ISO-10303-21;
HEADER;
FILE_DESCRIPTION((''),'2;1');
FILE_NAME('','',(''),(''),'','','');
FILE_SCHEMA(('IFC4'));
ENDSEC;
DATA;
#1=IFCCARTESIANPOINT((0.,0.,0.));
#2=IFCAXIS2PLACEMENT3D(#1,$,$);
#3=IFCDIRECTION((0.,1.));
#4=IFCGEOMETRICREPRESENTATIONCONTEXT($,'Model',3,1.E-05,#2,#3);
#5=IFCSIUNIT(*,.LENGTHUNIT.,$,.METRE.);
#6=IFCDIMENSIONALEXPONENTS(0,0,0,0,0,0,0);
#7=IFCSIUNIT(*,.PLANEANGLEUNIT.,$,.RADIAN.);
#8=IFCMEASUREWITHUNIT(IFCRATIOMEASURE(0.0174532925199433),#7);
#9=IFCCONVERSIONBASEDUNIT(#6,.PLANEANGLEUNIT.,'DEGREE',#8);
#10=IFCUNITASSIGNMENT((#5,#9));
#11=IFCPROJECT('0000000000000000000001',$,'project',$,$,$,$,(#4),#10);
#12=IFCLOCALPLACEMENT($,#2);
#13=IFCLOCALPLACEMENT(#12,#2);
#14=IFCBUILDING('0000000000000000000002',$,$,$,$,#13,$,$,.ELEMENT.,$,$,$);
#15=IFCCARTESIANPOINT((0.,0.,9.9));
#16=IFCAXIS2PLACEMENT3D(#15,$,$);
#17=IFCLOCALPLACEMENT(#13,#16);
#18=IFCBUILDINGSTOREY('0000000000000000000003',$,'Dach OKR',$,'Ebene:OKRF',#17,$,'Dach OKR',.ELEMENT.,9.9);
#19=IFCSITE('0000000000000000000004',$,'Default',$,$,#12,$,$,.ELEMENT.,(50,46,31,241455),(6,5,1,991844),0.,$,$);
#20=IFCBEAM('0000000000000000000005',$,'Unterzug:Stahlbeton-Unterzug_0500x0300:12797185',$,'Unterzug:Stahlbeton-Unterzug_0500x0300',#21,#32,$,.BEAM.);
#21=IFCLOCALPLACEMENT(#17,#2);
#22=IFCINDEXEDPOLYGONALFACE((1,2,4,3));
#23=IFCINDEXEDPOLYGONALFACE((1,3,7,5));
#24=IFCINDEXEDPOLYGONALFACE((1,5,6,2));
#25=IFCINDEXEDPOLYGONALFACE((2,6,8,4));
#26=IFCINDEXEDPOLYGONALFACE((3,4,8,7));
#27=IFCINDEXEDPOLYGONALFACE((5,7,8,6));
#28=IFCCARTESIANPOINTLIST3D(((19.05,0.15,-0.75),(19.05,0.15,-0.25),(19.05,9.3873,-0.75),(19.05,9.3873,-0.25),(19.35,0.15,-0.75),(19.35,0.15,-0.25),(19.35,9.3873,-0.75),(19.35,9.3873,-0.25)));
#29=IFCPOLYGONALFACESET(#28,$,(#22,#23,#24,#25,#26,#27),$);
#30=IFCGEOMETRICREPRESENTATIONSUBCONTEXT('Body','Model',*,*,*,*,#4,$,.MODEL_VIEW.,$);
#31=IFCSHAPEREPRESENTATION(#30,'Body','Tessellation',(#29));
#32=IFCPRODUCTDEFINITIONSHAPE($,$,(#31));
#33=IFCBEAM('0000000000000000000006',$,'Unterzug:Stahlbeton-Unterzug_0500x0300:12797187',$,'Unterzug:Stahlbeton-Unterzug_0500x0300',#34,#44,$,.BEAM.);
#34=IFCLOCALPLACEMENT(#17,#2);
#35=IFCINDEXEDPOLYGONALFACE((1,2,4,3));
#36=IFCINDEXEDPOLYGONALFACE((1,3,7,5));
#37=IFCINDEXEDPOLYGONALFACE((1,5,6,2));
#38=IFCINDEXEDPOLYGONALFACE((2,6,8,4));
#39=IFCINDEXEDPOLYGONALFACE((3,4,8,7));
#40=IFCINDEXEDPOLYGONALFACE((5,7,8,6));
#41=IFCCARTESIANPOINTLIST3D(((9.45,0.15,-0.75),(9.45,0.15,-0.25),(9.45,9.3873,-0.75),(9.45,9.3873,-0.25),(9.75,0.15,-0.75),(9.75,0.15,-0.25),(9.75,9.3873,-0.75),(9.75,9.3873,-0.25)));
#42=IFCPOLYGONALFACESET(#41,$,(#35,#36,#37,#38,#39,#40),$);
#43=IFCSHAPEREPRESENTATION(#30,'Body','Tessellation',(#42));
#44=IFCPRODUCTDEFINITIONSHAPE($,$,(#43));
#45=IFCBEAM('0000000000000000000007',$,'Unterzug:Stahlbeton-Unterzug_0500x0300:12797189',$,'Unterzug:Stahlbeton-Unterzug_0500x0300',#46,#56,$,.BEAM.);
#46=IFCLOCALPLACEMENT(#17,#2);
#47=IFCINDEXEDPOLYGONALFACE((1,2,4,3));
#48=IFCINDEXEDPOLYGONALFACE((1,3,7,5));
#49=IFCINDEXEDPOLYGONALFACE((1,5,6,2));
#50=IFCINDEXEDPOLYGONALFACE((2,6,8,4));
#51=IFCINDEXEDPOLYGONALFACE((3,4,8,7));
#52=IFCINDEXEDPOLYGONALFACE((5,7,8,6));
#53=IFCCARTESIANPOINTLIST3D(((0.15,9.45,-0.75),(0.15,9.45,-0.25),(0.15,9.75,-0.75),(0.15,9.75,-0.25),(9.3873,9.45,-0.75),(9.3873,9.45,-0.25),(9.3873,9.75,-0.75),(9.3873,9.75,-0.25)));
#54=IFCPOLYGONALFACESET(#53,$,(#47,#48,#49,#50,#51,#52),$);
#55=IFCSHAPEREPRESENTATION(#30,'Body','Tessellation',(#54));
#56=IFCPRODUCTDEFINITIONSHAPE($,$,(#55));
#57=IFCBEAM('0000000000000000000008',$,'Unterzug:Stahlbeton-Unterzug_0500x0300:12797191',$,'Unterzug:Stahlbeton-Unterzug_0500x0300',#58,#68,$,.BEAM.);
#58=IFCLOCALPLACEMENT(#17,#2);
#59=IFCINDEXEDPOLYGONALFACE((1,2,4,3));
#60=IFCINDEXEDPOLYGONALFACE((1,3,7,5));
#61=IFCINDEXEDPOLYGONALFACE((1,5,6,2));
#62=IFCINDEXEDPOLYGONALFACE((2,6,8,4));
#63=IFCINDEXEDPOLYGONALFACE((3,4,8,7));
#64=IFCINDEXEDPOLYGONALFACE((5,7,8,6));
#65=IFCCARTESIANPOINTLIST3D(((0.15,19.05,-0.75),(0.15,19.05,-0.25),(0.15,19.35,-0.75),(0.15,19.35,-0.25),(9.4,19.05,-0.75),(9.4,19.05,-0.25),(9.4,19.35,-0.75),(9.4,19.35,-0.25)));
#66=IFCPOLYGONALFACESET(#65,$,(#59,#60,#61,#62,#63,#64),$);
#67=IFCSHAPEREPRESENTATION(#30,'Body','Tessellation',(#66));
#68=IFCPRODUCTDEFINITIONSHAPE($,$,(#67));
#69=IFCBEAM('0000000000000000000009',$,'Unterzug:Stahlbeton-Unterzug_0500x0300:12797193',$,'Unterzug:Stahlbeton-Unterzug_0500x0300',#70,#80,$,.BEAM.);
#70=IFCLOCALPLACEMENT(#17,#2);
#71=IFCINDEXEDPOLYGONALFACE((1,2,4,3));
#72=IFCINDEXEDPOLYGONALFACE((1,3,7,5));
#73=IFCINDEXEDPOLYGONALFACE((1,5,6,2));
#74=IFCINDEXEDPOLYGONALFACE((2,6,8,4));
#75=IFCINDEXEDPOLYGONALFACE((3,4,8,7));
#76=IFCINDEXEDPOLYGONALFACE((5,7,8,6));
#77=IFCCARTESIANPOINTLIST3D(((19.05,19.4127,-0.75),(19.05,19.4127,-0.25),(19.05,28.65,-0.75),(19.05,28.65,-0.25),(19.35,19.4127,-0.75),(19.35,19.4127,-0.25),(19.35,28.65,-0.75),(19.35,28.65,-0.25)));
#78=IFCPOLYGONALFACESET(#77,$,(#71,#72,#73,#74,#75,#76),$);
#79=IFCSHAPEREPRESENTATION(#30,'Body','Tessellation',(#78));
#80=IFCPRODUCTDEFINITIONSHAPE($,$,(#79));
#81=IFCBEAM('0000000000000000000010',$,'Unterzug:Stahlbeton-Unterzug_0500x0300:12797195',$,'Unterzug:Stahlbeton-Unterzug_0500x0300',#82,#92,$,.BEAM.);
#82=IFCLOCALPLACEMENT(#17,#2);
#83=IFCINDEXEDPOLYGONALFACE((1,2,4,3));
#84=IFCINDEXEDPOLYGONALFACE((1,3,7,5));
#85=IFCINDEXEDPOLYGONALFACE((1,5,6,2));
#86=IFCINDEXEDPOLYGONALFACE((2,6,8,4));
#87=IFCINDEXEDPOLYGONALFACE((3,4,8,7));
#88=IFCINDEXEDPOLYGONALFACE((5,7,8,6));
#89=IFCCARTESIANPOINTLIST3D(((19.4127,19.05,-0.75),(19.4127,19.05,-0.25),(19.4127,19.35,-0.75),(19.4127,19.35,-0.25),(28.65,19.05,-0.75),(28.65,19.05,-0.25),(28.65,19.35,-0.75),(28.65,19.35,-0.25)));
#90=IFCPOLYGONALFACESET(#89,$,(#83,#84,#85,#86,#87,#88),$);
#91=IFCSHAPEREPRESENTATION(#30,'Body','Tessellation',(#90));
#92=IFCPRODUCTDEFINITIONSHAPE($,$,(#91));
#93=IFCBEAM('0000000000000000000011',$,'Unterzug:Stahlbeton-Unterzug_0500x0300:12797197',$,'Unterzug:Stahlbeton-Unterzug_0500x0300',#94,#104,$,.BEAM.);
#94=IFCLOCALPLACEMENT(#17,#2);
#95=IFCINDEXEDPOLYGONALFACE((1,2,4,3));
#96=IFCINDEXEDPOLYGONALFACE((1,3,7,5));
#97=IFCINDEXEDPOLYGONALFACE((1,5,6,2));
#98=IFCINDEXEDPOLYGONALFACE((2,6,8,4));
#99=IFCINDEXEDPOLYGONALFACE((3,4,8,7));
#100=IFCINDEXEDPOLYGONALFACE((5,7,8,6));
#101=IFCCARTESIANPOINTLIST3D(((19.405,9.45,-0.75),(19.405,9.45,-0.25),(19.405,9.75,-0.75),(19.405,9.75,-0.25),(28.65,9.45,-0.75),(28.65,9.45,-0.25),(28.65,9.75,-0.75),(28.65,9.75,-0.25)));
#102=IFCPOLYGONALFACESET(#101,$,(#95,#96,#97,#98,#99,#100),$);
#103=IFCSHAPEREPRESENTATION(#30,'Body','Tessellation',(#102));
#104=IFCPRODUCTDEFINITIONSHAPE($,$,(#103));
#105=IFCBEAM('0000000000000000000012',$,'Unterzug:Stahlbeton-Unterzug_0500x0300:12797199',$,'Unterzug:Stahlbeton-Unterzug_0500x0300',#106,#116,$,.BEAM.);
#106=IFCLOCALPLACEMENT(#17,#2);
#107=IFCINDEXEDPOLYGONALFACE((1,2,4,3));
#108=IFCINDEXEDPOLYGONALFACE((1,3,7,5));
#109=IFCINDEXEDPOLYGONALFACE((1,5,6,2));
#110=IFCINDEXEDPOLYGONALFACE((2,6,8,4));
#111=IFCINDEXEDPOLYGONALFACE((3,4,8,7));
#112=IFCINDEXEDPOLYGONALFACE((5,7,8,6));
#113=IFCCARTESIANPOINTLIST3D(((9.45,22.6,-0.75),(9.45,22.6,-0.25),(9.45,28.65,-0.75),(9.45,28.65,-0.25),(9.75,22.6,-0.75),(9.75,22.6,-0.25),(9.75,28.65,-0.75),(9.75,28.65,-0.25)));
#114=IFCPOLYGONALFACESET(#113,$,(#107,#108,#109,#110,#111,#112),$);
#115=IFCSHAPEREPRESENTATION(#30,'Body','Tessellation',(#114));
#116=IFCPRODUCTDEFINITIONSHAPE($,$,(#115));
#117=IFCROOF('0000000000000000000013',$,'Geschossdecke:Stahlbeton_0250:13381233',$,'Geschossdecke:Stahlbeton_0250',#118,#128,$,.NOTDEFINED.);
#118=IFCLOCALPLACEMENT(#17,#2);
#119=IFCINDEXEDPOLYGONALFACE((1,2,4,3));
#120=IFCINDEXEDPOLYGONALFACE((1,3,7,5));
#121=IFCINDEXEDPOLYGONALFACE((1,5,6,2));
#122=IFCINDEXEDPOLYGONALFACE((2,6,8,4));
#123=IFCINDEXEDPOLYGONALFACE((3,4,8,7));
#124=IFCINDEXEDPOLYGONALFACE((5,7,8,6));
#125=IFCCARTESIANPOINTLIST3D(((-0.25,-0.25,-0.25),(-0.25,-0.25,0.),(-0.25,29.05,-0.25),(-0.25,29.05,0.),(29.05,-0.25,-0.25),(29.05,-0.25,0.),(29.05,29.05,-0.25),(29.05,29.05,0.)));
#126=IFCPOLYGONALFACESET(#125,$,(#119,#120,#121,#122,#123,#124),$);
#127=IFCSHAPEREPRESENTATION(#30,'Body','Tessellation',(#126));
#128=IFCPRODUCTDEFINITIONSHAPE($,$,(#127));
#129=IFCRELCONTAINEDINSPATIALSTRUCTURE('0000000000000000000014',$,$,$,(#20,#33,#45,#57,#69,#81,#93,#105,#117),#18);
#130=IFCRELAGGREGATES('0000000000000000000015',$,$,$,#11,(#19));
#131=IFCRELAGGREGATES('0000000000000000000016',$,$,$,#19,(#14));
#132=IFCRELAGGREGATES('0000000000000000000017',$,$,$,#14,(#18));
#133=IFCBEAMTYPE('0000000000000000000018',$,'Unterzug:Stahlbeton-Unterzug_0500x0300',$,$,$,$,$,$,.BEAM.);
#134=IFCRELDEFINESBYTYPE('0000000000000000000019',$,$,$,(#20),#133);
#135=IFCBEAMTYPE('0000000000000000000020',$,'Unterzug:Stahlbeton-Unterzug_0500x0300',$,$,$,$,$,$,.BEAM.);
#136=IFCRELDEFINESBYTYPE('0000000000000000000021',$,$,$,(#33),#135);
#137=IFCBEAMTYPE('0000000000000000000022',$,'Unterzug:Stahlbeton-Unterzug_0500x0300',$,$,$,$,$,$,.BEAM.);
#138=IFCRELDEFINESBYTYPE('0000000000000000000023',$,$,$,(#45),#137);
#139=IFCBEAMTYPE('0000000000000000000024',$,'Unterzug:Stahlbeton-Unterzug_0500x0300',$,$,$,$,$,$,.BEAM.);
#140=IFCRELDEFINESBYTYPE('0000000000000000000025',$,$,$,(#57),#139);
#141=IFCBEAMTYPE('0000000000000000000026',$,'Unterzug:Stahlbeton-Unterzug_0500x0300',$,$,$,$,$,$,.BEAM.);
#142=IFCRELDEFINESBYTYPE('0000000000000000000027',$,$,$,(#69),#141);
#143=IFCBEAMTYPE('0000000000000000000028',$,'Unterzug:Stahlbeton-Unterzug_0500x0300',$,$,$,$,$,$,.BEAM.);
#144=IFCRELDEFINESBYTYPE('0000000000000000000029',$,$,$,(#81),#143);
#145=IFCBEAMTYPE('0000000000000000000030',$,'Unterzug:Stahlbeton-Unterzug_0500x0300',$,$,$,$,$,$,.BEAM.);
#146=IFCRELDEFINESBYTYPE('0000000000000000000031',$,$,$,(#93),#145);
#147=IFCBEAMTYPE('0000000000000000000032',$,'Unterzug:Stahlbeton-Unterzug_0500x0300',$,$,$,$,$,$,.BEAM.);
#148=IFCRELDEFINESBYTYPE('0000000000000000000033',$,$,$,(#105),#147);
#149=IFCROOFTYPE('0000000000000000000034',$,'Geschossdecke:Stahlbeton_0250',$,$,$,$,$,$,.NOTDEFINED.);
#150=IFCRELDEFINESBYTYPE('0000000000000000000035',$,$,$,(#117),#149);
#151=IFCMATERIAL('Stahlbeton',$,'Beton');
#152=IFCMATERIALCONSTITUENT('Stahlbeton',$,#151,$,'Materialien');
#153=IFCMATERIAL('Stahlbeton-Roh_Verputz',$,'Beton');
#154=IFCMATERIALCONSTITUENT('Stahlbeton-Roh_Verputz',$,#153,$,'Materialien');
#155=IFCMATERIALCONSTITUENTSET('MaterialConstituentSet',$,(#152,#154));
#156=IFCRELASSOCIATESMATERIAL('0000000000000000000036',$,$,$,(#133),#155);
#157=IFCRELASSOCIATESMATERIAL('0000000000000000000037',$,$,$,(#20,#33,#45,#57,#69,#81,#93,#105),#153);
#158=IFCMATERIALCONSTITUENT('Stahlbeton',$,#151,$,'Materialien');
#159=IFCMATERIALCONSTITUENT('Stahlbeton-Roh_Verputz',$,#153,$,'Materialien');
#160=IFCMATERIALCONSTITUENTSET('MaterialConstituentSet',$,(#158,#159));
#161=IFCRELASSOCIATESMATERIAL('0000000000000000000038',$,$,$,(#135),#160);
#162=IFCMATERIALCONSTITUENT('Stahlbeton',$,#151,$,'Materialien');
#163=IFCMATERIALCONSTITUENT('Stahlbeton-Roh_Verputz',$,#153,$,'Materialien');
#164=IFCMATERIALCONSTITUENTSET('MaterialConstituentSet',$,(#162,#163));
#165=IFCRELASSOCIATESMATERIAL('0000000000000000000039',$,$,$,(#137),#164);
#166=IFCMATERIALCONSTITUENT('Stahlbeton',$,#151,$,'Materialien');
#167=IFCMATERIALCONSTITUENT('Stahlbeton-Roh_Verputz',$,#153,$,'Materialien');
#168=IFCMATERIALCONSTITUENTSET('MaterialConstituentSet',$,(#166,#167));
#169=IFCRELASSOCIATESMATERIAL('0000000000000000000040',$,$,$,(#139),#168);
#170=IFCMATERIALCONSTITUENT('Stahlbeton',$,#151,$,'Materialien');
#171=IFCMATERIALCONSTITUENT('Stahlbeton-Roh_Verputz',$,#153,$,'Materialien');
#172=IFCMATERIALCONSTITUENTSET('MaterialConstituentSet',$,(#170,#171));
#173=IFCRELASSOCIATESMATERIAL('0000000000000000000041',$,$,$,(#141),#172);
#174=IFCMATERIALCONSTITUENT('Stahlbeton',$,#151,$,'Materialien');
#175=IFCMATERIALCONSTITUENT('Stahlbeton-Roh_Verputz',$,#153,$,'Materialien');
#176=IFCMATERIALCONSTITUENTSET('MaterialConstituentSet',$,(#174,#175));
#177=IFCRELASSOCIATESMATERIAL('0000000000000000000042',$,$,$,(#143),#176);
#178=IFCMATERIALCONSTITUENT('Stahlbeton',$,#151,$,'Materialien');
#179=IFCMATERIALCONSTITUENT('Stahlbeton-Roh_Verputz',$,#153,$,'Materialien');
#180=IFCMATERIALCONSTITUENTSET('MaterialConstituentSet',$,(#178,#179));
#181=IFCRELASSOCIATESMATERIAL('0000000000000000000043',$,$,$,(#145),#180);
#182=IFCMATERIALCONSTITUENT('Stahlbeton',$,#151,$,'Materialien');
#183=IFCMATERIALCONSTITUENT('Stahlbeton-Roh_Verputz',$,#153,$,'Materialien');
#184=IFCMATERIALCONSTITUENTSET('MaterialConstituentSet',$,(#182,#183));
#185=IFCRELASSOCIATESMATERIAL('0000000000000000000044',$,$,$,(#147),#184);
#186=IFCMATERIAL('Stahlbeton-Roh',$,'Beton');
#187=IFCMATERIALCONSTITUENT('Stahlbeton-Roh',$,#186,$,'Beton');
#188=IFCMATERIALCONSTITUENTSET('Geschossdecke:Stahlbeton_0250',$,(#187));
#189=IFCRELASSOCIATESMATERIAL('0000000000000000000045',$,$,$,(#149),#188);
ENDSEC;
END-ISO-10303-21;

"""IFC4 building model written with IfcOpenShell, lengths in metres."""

from ifc_helpers import new_model, entity, si_unit, converted_unit, direction, frame, origin, place, context, subcontext, project, spatial, polyline, indexed_curve, outline, extrude, source, transform, mapped, material, constituent, constituent_set, type_object, type_shapes, element, save


model = new_model("IFC4")

# Units and contexts
model_context = context("Model", 3, precision=1e-05, world=origin(), true_north=direction((0.0, 1.0)))
body_context = subcontext(model_context, "Body", "Model", "MODEL_VIEW")
ifc_project = project(units=[si_unit("LENGTHUNIT", "METRE"), converted_unit("PLANEANGLEUNIT", "DEGREE", entity("IfcRatioMeasure", 0.0174532925199433), si_unit("PLANEANGLEUNIT", "RADIAN"), dimensions=[0, 0, 0, 0, 0, 0, 0])], contexts=[model_context])

# Site, building, storey
site_placement = place(None, origin())
site = spatial("IfcSite", under=ifc_project, at=site_placement, Name="Default", CompositionType="ELEMENT", RefLatitude=(50, 46, 31, 241455), RefLongitude=(6, 5, 1, 991844), RefElevation=0.0)
building_placement = place(site_placement, origin())
building = spatial("IfcBuilding", under=site, at=building_placement, CompositionType="ELEMENT")
storey_placement = place(building_placement, frame((0.0, 0.0, 9.9)))
storey = spatial("IfcBuildingStorey", under=building, at=storey_placement, Name="Dach OKR", ObjectType="Ebene:OKRF", LongName="Dach OKR", CompositionType="ELEMENT", Elevation=9.9)

# Beams
ifc_material_1 = material(Name="Stahlbeton-Roh_Verputz", Category="Beton")
ifc_material_2 = material(Name="Stahlbeton", Category="Beton")
ifc_constituent_1 = constituent(ifc_material_2, Name="Stahlbeton", Category="Materialien")
ifc_constituent_2 = constituent(ifc_material_1, Name="Stahlbeton-Roh_Verputz", Category="Materialien")
ifc_constituent_set_1 = constituent_set(constituents=[ifc_constituent_1, ifc_constituent_2], Name="MaterialConstituentSet")
beam_type_1 = type_object("IfcBeamType", Name="Unterzug:Stahlbeton-Unterzug_0500x0300", PredefinedType="BEAM", material=ifc_constituent_set_1)
shared_shape_1 = source(origin(), body_context, "Body", "SweptSolid", [
    extrude(outline(indexed_curve([(-0.15, -0.25), (0.15, -0.25), (0.15, 0.25), (-0.15, 0.25), (-0.15, -0.25)], self_intersect=False)), frame((19.2, 9.3873, 9.4), z_axis=(0.0, -1.0, 0.0), x_axis=(-1.0, 0.0, 0.0)), (0.0, 0.0, 1.0), 9.2373),
])
type_shapes(beam_type_1, [shared_shape_1])
beam_1_placement = place(storey_placement, frame((0.0, 0.0, -9.9)))
element("IfcBeam", 1, at=beam_1_placement, inside=storey, type_object=beam_type_1, material=ifc_material_1, Name="Unterzug:Stahlbeton-Unterzug_0500x0300:12797185", ObjectType="Unterzug:Stahlbeton-Unterzug_0500x0300", PredefinedType="BEAM", context=body_context, shape_type="MappedRepresentation", body=[
    mapped(shared_shape_1, transform((0.0, 0.0, 0.0), scale=1.0)),
])
ifc_constituent_3 = constituent(ifc_material_2, Name="Stahlbeton", Category="Materialien")
ifc_constituent_4 = constituent(ifc_material_1, Name="Stahlbeton-Roh_Verputz", Category="Materialien")
ifc_constituent_set_2 = constituent_set(constituents=[ifc_constituent_3, ifc_constituent_4], Name="MaterialConstituentSet")
beam_type_2 = type_object("IfcBeamType", Name="Unterzug:Stahlbeton-Unterzug_0500x0300", PredefinedType="BEAM", material=ifc_constituent_set_2)
shared_shape_2 = source(origin(), body_context, "Body", "SweptSolid", [
    extrude(outline(indexed_curve([(-0.15, -0.25), (0.15, -0.25), (0.15, 0.25), (-0.15, 0.25), (-0.15, -0.25)], self_intersect=False)), frame((9.6, 9.3873, 9.4), z_axis=(0.0, -1.0, 0.0), x_axis=(-1.0, 0.0, 0.0)), (0.0, 0.0, 1.0), 9.2373),
])
type_shapes(beam_type_2, [shared_shape_2])
beam_2_placement = place(storey_placement, frame((0.0, 0.0, -9.9)))
element("IfcBeam", 2, at=beam_2_placement, inside=storey, type_object=beam_type_2, material=ifc_material_1, Name="Unterzug:Stahlbeton-Unterzug_0500x0300:12797187", ObjectType="Unterzug:Stahlbeton-Unterzug_0500x0300", PredefinedType="BEAM", context=body_context, shape_type="MappedRepresentation", body=[
    mapped(shared_shape_2, transform((0.0, 0.0, 0.0), scale=1.0)),
])
ifc_constituent_5 = constituent(ifc_material_2, Name="Stahlbeton", Category="Materialien")
ifc_constituent_6 = constituent(ifc_material_1, Name="Stahlbeton-Roh_Verputz", Category="Materialien")
ifc_constituent_set_3 = constituent_set(constituents=[ifc_constituent_5, ifc_constituent_6], Name="MaterialConstituentSet")
beam_type_3 = type_object("IfcBeamType", Name="Unterzug:Stahlbeton-Unterzug_0500x0300", PredefinedType="BEAM", material=ifc_constituent_set_3)
shared_shape_3 = source(origin(), body_context, "Body", "SweptSolid", [
    extrude(outline(indexed_curve([(-0.25, -0.15), (0.25, -0.15), (0.25, 0.15), (-0.25, 0.15), (-0.25, -0.15)], self_intersect=False)), frame((9.3873, 9.6, 9.4), z_axis=(-1.0, 0.0, 0.0), x_axis=(0.0, 0.0, -1.0)), (0.0, 0.0, 1.0), 9.2373),
])
type_shapes(beam_type_3, [shared_shape_3])
beam_3_placement = place(storey_placement, frame((0.0, 0.0, -9.9)))
element("IfcBeam", 3, at=beam_3_placement, inside=storey, type_object=beam_type_3, material=ifc_material_1, Name="Unterzug:Stahlbeton-Unterzug_0500x0300:12797189", ObjectType="Unterzug:Stahlbeton-Unterzug_0500x0300", PredefinedType="BEAM", context=body_context, shape_type="MappedRepresentation", body=[
    mapped(shared_shape_3, transform((0.0, 0.0, 0.0), scale=1.0)),
])
ifc_constituent_7 = constituent(ifc_material_2, Name="Stahlbeton", Category="Materialien")
ifc_constituent_8 = constituent(ifc_material_1, Name="Stahlbeton-Roh_Verputz", Category="Materialien")
ifc_constituent_set_4 = constituent_set(constituents=[ifc_constituent_7, ifc_constituent_8], Name="MaterialConstituentSet")
beam_type_4 = type_object("IfcBeamType", Name="Unterzug:Stahlbeton-Unterzug_0500x0300", PredefinedType="BEAM", material=ifc_constituent_set_4)
shared_shape_4 = source(origin(), body_context, "Body", "SweptSolid", [
    extrude(outline(indexed_curve([(-0.25, -0.15), (0.25, -0.15), (0.25, 0.15), (-0.25, 0.15), (-0.25, -0.15)], self_intersect=False)), frame((9.4, 19.2, 9.4), z_axis=(-1.0, 0.0, 0.0), x_axis=(0.0, 0.0, -1.0)), (0.0, 0.0, 1.0), 9.25),
])
type_shapes(beam_type_4, [shared_shape_4])
beam_4_placement = place(storey_placement, frame((0.0, 0.0, -9.9)))
element("IfcBeam", 4, at=beam_4_placement, inside=storey, type_object=beam_type_4, material=ifc_material_1, Name="Unterzug:Stahlbeton-Unterzug_0500x0300:12797191", ObjectType="Unterzug:Stahlbeton-Unterzug_0500x0300", PredefinedType="BEAM", context=body_context, shape_type="MappedRepresentation", body=[
    mapped(shared_shape_4, transform((0.0, 0.0, 0.0), scale=1.0)),
])
ifc_constituent_9 = constituent(ifc_material_2, Name="Stahlbeton", Category="Materialien")
ifc_constituent_10 = constituent(ifc_material_1, Name="Stahlbeton-Roh_Verputz", Category="Materialien")
ifc_constituent_set_5 = constituent_set(constituents=[ifc_constituent_9, ifc_constituent_10], Name="MaterialConstituentSet")
beam_type_5 = type_object("IfcBeamType", Name="Unterzug:Stahlbeton-Unterzug_0500x0300", PredefinedType="BEAM", material=ifc_constituent_set_5)
shared_shape_5 = source(origin(), body_context, "Body", "SweptSolid", [
    extrude(outline(indexed_curve([(-0.15, -0.25), (0.15, -0.25), (0.15, 0.25), (-0.15, 0.25), (-0.15, -0.25)], self_intersect=False)), frame((19.2, 19.4127, 9.4), z_axis=(0.0, 1.0, 0.0), x_axis=(-1.0, 0.0, 0.0)), (0.0, 0.0, 1.0), 9.2373),
])
type_shapes(beam_type_5, [shared_shape_5])
beam_5_placement = place(storey_placement, frame((0.0, 0.0, -9.9)))
element("IfcBeam", 5, at=beam_5_placement, inside=storey, type_object=beam_type_5, material=ifc_material_1, Name="Unterzug:Stahlbeton-Unterzug_0500x0300:12797193", ObjectType="Unterzug:Stahlbeton-Unterzug_0500x0300", PredefinedType="BEAM", context=body_context, shape_type="MappedRepresentation", body=[
    mapped(shared_shape_5, transform((0.0, 0.0, 0.0), scale=1.0)),
])
ifc_constituent_11 = constituent(ifc_material_2, Name="Stahlbeton", Category="Materialien")
ifc_constituent_12 = constituent(ifc_material_1, Name="Stahlbeton-Roh_Verputz", Category="Materialien")
ifc_constituent_set_6 = constituent_set(constituents=[ifc_constituent_11, ifc_constituent_12], Name="MaterialConstituentSet")
beam_type_6 = type_object("IfcBeamType", Name="Unterzug:Stahlbeton-Unterzug_0500x0300", PredefinedType="BEAM", material=ifc_constituent_set_6)
shared_shape_6 = source(origin(), body_context, "Body", "SweptSolid", [
    extrude(outline(indexed_curve([(-0.25, -0.15), (0.25, -0.15), (0.25, 0.15), (-0.25, 0.15), (-0.25, -0.15)], self_intersect=False)), frame((19.4127, 19.2, 9.4), z_axis=(1.0, 0.0, 0.0), x_axis=(0.0, 0.0, -1.0)), (0.0, 0.0, 1.0), 9.2373),
])
type_shapes(beam_type_6, [shared_shape_6])
beam_6_placement = place(storey_placement, frame((0.0, 0.0, -9.9)))
element("IfcBeam", 6, at=beam_6_placement, inside=storey, type_object=beam_type_6, material=ifc_material_1, Name="Unterzug:Stahlbeton-Unterzug_0500x0300:12797195", ObjectType="Unterzug:Stahlbeton-Unterzug_0500x0300", PredefinedType="BEAM", context=body_context, shape_type="MappedRepresentation", body=[
    mapped(shared_shape_6, transform((0.0, 0.0, 0.0), scale=1.0)),
])
ifc_constituent_13 = constituent(ifc_material_2, Name="Stahlbeton", Category="Materialien")
ifc_constituent_14 = constituent(ifc_material_1, Name="Stahlbeton-Roh_Verputz", Category="Materialien")
ifc_constituent_set_7 = constituent_set(constituents=[ifc_constituent_13, ifc_constituent_14], Name="MaterialConstituentSet")
beam_type_7 = type_object("IfcBeamType", Name="Unterzug:Stahlbeton-Unterzug_0500x0300", PredefinedType="BEAM", material=ifc_constituent_set_7)
shared_shape_7 = source(origin(), body_context, "Body", "SweptSolid", [
    extrude(outline(indexed_curve([(-0.25, -0.15), (0.25, -0.15), (0.25, 0.15), (-0.25, 0.15), (-0.25, -0.15)], self_intersect=False)), frame((19.405, 9.6, 9.4), z_axis=(1.0, 0.0, 0.0), x_axis=(0.0, 0.0, -1.0)), (0.0, 0.0, 1.0), 9.245),
])
type_shapes(beam_type_7, [shared_shape_7])
beam_7_placement = place(storey_placement, frame((0.0, 0.0, -9.9)))
element("IfcBeam", 7, at=beam_7_placement, inside=storey, type_object=beam_type_7, material=ifc_material_1, Name="Unterzug:Stahlbeton-Unterzug_0500x0300:12797197", ObjectType="Unterzug:Stahlbeton-Unterzug_0500x0300", PredefinedType="BEAM", context=body_context, shape_type="MappedRepresentation", body=[
    mapped(shared_shape_7, transform((0.0, 0.0, 0.0), scale=1.0)),
])
ifc_constituent_15 = constituent(ifc_material_2, Name="Stahlbeton", Category="Materialien")
ifc_constituent_16 = constituent(ifc_material_1, Name="Stahlbeton-Roh_Verputz", Category="Materialien")
ifc_constituent_set_8 = constituent_set(constituents=[ifc_constituent_15, ifc_constituent_16], Name="MaterialConstituentSet")
beam_type_8 = type_object("IfcBeamType", Name="Unterzug:Stahlbeton-Unterzug_0500x0300", PredefinedType="BEAM", material=ifc_constituent_set_8)
shared_shape_8 = source(origin(), body_context, "Body", "SweptSolid", [
    extrude(outline(indexed_curve([(-0.15, -0.25), (0.15, -0.25), (0.15, 0.25), (-0.15, 0.25), (-0.15, -0.25)], self_intersect=False)), frame((9.6, 22.6, 9.4), z_axis=(0.0, 1.0, 0.0), x_axis=(-1.0, 0.0, 0.0)), (0.0, 0.0, 1.0), 6.05),
])
type_shapes(beam_type_8, [shared_shape_8])
beam_8_placement = place(storey_placement, frame((0.0, 0.0, -9.9)))
element("IfcBeam", 8, at=beam_8_placement, inside=storey, type_object=beam_type_8, material=ifc_material_1, Name="Unterzug:Stahlbeton-Unterzug_0500x0300:12797199", ObjectType="Unterzug:Stahlbeton-Unterzug_0500x0300", PredefinedType="BEAM", context=body_context, shape_type="MappedRepresentation", body=[
    mapped(shared_shape_8, transform((0.0, 0.0, 0.0), scale=1.0)),
])

# Roof
ifc_material_3 = material(Name="Stahlbeton-Roh", Category="Beton")
ifc_constituent_17 = constituent(ifc_material_3, Name="Stahlbeton-Roh", Category="Beton")
ifc_constituent_set_9 = constituent_set(constituents=[ifc_constituent_17], Name="Geschossdecke:Stahlbeton_0250")
roof_type = type_object("IfcRoofType", Name="Geschossdecke:Stahlbeton_0250", PredefinedType="NOTDEFINED", material=ifc_constituent_set_9)
roof_1_placement = place(storey_placement, origin())
element("IfcRoof", 9, at=roof_1_placement, inside=storey, type_object=roof_type, Name="Geschossdecke:Stahlbeton_0250:13381233", ObjectType="Geschossdecke:Stahlbeton_0250", PredefinedType="NOTDEFINED", context=body_context, shape_type="SweptSolid", body=[
    extrude(outline(polyline([(-14.65, -14.65), (14.65, -14.65), (14.65, 14.65), (-14.65, 14.65), (-14.65, -14.65)])), frame((14.4, 14.4, -0.25), z_axis=(0.0, 0.0, -1.0), x_axis=(0.0, -1.0, 0.0)), (0.0, 0.0, -1.0), 0.25),
])

save(model, "model.ifc")
